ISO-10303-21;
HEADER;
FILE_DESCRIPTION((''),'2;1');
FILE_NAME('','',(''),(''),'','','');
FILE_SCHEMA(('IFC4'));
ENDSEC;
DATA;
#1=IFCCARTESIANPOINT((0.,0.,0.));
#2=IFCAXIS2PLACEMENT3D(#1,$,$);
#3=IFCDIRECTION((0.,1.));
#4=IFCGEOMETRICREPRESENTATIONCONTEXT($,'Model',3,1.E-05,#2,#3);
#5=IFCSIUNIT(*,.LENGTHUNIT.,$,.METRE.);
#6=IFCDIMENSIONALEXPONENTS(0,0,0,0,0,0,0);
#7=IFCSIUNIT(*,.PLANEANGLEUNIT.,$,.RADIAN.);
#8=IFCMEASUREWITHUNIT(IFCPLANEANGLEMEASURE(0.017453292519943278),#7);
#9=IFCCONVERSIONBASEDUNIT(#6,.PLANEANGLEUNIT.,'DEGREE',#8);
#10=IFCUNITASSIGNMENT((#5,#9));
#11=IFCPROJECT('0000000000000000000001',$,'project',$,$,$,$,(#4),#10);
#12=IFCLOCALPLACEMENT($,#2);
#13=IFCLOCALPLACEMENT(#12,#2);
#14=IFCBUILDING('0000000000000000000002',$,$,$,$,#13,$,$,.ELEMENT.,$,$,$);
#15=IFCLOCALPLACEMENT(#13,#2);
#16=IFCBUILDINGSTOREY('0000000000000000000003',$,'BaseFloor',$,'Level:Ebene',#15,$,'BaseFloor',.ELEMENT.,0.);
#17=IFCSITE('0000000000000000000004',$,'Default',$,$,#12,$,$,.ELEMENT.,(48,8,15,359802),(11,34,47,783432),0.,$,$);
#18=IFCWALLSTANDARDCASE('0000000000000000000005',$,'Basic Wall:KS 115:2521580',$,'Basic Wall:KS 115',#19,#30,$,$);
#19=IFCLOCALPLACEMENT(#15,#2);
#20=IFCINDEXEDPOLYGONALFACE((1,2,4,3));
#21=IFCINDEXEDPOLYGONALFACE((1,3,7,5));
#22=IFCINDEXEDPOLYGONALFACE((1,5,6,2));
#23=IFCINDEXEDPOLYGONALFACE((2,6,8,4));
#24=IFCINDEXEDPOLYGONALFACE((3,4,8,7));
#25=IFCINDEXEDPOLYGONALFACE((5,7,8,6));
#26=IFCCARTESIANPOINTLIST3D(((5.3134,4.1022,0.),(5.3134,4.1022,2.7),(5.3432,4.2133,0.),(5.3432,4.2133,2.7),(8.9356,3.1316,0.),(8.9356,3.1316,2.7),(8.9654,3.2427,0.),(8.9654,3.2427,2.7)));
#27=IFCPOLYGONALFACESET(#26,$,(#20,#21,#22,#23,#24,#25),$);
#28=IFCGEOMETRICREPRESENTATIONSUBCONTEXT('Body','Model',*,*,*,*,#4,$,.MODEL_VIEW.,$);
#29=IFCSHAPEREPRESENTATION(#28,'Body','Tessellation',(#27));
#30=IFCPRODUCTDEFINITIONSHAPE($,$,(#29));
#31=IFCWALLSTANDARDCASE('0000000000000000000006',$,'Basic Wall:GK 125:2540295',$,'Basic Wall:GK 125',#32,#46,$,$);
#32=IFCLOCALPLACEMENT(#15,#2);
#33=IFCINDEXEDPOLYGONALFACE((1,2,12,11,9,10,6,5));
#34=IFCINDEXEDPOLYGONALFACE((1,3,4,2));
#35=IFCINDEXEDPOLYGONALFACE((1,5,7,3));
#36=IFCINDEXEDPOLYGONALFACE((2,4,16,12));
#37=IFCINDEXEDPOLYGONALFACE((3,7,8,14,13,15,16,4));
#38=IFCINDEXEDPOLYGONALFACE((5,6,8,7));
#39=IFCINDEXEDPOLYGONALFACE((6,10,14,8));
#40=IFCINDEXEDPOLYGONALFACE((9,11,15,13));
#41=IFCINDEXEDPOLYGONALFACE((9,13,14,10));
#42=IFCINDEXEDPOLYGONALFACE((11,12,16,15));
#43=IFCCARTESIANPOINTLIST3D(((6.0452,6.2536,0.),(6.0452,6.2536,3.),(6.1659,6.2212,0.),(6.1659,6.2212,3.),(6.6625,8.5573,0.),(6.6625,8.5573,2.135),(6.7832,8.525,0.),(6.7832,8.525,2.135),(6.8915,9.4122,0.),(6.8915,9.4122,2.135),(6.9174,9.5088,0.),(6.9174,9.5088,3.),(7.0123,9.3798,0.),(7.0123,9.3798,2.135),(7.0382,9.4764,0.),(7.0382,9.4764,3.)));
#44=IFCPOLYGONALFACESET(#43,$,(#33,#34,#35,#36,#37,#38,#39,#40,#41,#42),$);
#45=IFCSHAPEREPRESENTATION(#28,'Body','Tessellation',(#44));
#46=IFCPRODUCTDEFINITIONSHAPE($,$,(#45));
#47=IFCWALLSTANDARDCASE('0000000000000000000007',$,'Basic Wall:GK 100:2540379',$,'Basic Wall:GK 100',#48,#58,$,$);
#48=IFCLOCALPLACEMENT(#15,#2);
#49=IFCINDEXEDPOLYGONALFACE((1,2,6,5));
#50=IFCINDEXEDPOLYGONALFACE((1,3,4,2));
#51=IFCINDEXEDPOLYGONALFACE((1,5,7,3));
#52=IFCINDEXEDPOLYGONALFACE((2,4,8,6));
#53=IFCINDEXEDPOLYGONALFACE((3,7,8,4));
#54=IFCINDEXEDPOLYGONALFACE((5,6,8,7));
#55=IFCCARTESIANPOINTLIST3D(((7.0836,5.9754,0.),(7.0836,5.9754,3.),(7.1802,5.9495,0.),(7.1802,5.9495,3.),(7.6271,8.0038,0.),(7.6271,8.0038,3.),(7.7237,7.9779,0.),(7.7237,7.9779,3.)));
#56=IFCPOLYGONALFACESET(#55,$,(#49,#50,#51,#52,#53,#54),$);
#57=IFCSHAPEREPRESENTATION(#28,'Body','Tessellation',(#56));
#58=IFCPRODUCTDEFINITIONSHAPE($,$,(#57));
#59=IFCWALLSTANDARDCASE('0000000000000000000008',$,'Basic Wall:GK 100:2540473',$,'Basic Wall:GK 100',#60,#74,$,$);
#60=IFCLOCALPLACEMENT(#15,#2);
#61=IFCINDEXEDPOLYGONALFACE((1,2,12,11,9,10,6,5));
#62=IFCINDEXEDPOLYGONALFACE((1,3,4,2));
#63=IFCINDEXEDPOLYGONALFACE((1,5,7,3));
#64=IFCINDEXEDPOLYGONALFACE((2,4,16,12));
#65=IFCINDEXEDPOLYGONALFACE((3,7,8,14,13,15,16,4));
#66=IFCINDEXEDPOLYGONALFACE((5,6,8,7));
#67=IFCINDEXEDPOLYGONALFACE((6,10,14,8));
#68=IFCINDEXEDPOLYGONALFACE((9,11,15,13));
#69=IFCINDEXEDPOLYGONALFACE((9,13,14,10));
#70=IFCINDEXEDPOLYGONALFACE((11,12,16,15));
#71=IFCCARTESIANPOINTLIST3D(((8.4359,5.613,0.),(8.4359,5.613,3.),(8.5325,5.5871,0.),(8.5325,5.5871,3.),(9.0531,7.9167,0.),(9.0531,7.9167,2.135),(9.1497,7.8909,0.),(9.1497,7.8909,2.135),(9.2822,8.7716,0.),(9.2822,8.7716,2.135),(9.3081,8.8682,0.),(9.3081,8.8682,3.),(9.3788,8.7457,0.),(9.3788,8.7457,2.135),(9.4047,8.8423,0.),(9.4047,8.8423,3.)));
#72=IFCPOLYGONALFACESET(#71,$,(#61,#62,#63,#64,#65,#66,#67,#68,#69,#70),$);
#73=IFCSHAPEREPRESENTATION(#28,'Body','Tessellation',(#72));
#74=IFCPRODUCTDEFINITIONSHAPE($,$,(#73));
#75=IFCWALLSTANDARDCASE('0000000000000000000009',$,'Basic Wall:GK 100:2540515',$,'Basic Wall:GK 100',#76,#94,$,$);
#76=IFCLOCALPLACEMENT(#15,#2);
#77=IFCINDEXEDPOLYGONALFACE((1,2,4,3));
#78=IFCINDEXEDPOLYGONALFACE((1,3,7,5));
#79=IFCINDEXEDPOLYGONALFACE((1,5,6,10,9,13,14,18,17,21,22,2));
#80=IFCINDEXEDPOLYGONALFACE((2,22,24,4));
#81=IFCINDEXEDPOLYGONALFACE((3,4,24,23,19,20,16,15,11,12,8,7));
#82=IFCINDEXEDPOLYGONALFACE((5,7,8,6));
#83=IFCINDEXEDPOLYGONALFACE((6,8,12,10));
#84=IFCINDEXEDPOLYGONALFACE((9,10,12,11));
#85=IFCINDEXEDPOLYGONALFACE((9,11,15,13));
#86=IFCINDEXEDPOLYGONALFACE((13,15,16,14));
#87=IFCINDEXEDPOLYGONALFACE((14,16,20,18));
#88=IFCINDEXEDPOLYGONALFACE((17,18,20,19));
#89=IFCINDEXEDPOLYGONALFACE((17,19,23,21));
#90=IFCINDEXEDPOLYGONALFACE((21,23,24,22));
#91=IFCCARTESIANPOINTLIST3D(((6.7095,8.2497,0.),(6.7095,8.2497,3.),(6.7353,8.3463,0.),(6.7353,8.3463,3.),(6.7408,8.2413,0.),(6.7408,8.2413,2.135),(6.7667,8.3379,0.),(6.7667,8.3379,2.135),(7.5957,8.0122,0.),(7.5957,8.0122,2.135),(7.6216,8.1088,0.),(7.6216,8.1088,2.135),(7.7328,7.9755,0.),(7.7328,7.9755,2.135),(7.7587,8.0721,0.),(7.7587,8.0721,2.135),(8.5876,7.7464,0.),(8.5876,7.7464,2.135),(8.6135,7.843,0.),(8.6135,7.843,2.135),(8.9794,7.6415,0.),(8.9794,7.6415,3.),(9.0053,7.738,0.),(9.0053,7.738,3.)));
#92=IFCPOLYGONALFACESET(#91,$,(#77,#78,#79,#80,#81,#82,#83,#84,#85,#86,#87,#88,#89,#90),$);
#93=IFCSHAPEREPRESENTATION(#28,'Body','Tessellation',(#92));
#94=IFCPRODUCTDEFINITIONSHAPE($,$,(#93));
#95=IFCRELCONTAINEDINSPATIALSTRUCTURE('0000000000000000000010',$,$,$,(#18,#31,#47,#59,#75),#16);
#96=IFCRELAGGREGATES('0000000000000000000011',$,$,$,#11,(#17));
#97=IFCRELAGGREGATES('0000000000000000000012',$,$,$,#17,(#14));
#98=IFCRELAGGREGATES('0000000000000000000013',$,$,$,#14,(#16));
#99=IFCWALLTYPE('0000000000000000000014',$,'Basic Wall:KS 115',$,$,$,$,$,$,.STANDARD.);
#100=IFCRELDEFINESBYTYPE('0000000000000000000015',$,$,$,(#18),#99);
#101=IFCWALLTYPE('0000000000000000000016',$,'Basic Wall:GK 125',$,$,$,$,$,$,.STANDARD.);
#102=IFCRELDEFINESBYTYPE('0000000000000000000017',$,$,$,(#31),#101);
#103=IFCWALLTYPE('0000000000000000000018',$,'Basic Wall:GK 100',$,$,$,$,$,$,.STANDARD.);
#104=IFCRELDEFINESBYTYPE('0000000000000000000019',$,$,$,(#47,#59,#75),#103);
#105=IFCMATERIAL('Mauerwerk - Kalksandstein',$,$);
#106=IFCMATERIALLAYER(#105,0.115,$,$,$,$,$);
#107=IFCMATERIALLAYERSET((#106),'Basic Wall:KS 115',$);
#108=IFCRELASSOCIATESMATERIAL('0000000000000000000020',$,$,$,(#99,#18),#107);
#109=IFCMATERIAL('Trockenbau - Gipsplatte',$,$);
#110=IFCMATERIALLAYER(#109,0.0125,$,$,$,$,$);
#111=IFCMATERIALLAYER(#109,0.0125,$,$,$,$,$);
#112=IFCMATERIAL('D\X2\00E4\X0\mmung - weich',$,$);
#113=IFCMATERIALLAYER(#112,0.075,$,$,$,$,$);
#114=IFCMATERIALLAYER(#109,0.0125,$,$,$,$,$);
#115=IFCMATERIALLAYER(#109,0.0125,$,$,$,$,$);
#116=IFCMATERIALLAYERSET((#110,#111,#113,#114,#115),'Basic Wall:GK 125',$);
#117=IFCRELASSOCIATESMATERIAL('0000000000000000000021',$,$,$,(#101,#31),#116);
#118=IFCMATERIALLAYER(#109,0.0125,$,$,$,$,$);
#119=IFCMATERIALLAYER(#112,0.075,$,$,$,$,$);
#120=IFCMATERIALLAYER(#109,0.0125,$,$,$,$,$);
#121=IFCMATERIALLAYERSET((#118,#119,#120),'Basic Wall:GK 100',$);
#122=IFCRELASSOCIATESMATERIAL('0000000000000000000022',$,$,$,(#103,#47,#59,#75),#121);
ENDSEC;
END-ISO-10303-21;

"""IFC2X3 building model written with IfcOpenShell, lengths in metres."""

from ifc_helpers import new_model, entity, si_unit, converted_unit, direction, frame, frame_2d, origin, place, context, subcontext, project, spatial, rectangle, extrude, material, layer, layer_set, layer_usage, type_object, element, save


model = new_model("IFC2X3")

# Units and contexts
model_context = context("Model", 3, precision=1e-05, world=origin(), true_north=direction((0.0, 1.0)))
body_context = subcontext(model_context, "Body", "Model", "MODEL_VIEW")
ifc_project = project(units=[si_unit("LENGTHUNIT", "METRE"), converted_unit("PLANEANGLEUNIT", "DEGREE", entity("IfcPlaneAngleMeasure", 0.017453292519943278), si_unit("PLANEANGLEUNIT", "RADIAN"), dimensions=[0, 0, 0, 0, 0, 0, 0])], contexts=[model_context])

# Site, building, storey
site_placement = place(None, origin())
site = spatial("IfcSite", under=ifc_project, at=site_placement, Name="Default", CompositionType="ELEMENT", RefLatitude=(48, 8, 15, 359802), RefLongitude=(11, 34, 47, 783432), RefElevation=0.0)
building_placement = place(site_placement, origin())
building = spatial("IfcBuilding", under=site, at=building_placement, CompositionType="ELEMENT")
storey_placement = place(building_placement, origin())
storey = spatial("IfcBuildingStorey", under=building, at=storey_placement, Name="BaseFloor", ObjectType="Level:Ebene", LongName="BaseFloor", CompositionType="ELEMENT", Elevation=0.0)

# Wall
ifc_material_1 = material(Name="Mauerwerk - Kalksandstein")
ifc_layer_1 = layer(ifc_material_1, 0.115)
ifc_layer_set_1 = layer_set([ifc_layer_1], Name="Basic Wall:KS 115")
ifc_layer_usage_1 = layer_usage(ifc_layer_set_1, "AXIS2", "NEGATIVE", 0.0575)
wall_type_1 = type_object("IfcWallType", Name="Basic Wall:KS 115", PredefinedType="STANDARD", material=ifc_layer_set_1)
wall_1_placement = place(storey_placement, frame((8.9505, 3.1871, 0.0), z_axis=(0.0, 0.0, 1.0), x_axis=(-0.965926, 0.258819, 0.0)))
element("IfcWallStandardCase", 1, at=wall_1_placement, inside=storey, type_object=wall_type_1, material=ifc_layer_usage_1, Name="Basic Wall:KS 115:2521580", ObjectType="Basic Wall:KS 115", context=body_context, shape_type="SweptSolid", body=[
    extrude(rectangle(XDim=3.75, YDim=0.115, at=frame_2d((1.875, 0.0), x_axis=(-1.0, 0.0))), origin(), (0.0, 0.0, 1.0), 2.7),
])

# Wall, opening
ifc_material_2 = material(Name="Trockenbau - Gipsplatte")
ifc_layer_2 = layer(ifc_material_2, 0.0125)
ifc_layer_3 = layer(ifc_material_2, 0.0125)
ifc_material_3 = material(Name="Dämmung - weich")
ifc_layer_4 = layer(ifc_material_3, 0.075)
ifc_layer_5 = layer(ifc_material_2, 0.0125)
ifc_layer_6 = layer(ifc_material_2, 0.0125)
ifc_layer_set_2 = layer_set([ifc_layer_2, ifc_layer_3, ifc_layer_4, ifc_layer_5, ifc_layer_6], Name="Basic Wall:GK 125")
ifc_layer_usage_2 = layer_usage(ifc_layer_set_2, "AXIS2", "NEGATIVE", 0.0625)
wall_type_2 = type_object("IfcWallType", Name="Basic Wall:GK 125", PredefinedType="STANDARD", material=ifc_layer_set_2)
wall_2_placement = place(storey_placement, frame((6.1056, 6.2374, 0.0), z_axis=(0.0, 0.0, 1.0), x_axis=(0.258819, 0.965926, 0.0)))
wall_2 = element("IfcWallStandardCase", 2, at=wall_2_placement, inside=storey, type_object=wall_type_2, material=ifc_layer_usage_2, Name="Basic Wall:GK 125:2540295", ObjectType="Basic Wall:GK 125", context=body_context, shape_type="SweptSolid", body=[
    extrude(rectangle(XDim=3.37, YDim=0.125, at=frame_2d((1.685, 0.0), x_axis=(1.0, 0.0))), origin(), (0.0, 0.0, 1.0), 3.0),
])
opening_1_placement = place(wall_2_placement, frame((2.385, -0.0625, -0.18)))
element("IfcOpeningElement", 3, at=opening_1_placement, cuts=wall_2, ObjectType="Opening", context=body_context, shape_type="SweptSolid", body=[
    extrude(rectangle(XDim=2.315, YDim=0.885, at=frame_2d((1.1575, 0.4425), x_axis=(-1.0, 0.0))), frame((0.0, 0.0, 0.0), z_axis=(0.0, 1.0, 0.0), x_axis=(0.0, 0.0, 1.0)), (0.0, 0.0, 1.0), 0.125),
])

# Wall
ifc_layer_7 = layer(ifc_material_2, 0.0125)
ifc_layer_8 = layer(ifc_material_3, 0.075)
ifc_layer_9 = layer(ifc_material_2, 0.0125)
ifc_layer_set_3 = layer_set([ifc_layer_7, ifc_layer_8, ifc_layer_9], Name="Basic Wall:GK 100")
ifc_layer_usage_3 = layer_usage(ifc_layer_set_3, "AXIS2", "NEGATIVE", 0.05)
wall_type_3 = type_object("IfcWallType", Name="Basic Wall:GK 100", PredefinedType="STANDARD", material=ifc_layer_set_3)
wall_3_placement = place(storey_placement, frame((7.1319, 5.9624, 0.0), z_axis=(0.0, 0.0, 1.0), x_axis=(0.258819, 0.965926, 0.0)))
element("IfcWallStandardCase", 4, at=wall_3_placement, inside=storey, type_object=wall_type_3, material=ifc_layer_usage_3, Name="Basic Wall:GK 100:2540379", ObjectType="Basic Wall:GK 100", context=body_context, shape_type="SweptSolid", body=[
    extrude(rectangle(XDim=2.1, YDim=0.1, at=frame_2d((1.05, 0.0), x_axis=(-1.0, 0.0))), origin(), (0.0, 0.0, 1.0), 3.0),
])

# Wall, opening
ifc_layer_usage_4 = layer_usage(ifc_layer_set_3, "AXIS2", "NEGATIVE", 0.05)
wall_4_placement = place(storey_placement, frame((8.4842, 5.6001, 0.0), z_axis=(0.0, 0.0, 1.0), x_axis=(0.258819, 0.965926, 0.0)))
wall_4 = element("IfcWallStandardCase", 5, at=wall_4_placement, inside=storey, type_object=wall_type_3, material=ifc_layer_usage_4, Name="Basic Wall:GK 100:2540473", ObjectType="Basic Wall:GK 100", context=body_context, shape_type="SweptSolid", body=[
    extrude(rectangle(XDim=3.37, YDim=0.1, at=frame_2d((1.685, 0.0), x_axis=(-1.0, 0.0))), origin(), (0.0, 0.0, 1.0), 3.0),
])
opening_2_placement = place(wall_4_placement, frame((3.27, 0.05, -0.18)))
element("IfcOpeningElement", 6, at=opening_2_placement, cuts=wall_4, ObjectType="Opening", context=body_context, shape_type="SweptSolid", body=[
    extrude(rectangle(XDim=2.315, YDim=0.885, at=frame_2d((1.1575, 0.4425), x_axis=(-1.0, 0.0))), frame((0.0, 0.0, 0.0), z_axis=(0.0, -1.0, 0.0), x_axis=(0.0, 0.0, 1.0)), (0.0, 0.0, 1.0), 0.1),
])

# Wall, openings
ifc_layer_usage_5 = layer_usage(ifc_layer_set_3, "AXIS2", "NEGATIVE", 0.05)
wall_5_placement = place(storey_placement, frame((8.9923, 7.6898, 0.0), z_axis=(0.0, 0.0, 1.0), x_axis=(-0.965926, 0.258819, 0.0)))
wall_5 = element("IfcWallStandardCase", 7, at=wall_5_placement, inside=storey, type_object=wall_type_3, material=ifc_layer_usage_5, Name="Basic Wall:GK 100:2540515", ObjectType="Basic Wall:GK 100", context=body_context, shape_type="SweptSolid", body=[
    extrude(rectangle(XDim=2.35, YDim=0.1, at=frame_2d((1.175, 0.0), x_axis=(1.0, 0.0))), origin(), (0.0, 0.0, 1.0), 3.0),
])
opening_3_placement = place(wall_5_placement, frame((1.4325, -0.05, -0.18)))
element("IfcOpeningElement", 8, at=opening_3_placement, cuts=wall_5, ObjectType="Opening", context=body_context, shape_type="SweptSolid", body=[
    extrude(rectangle(XDim=2.315, YDim=0.885, at=frame_2d((1.1575, 0.4425), x_axis=(-1.0, 0.0))), frame((0.0, 0.0, 0.0), z_axis=(0.0, 1.0, 0.0), x_axis=(0.0, 0.0, 1.0)), (0.0, 0.0, 1.0), 0.1),
])
opening_4_placement = place(wall_5_placement, frame((0.4056, -0.05, -0.18)))
element("IfcOpeningElement", 9, at=opening_4_placement, cuts=wall_5, ObjectType="Opening", context=body_context, shape_type="SweptSolid", body=[
    extrude(rectangle(XDim=2.315, YDim=0.885, at=frame_2d((1.1575, 0.4425), x_axis=(-1.0, 0.0))), frame((0.0, 0.0, 0.0), z_axis=(0.0, 1.0, 0.0), x_axis=(0.0, 0.0, 1.0)), (0.0, 0.0, 1.0), 0.1),
])

save(model, "model.ifc")
